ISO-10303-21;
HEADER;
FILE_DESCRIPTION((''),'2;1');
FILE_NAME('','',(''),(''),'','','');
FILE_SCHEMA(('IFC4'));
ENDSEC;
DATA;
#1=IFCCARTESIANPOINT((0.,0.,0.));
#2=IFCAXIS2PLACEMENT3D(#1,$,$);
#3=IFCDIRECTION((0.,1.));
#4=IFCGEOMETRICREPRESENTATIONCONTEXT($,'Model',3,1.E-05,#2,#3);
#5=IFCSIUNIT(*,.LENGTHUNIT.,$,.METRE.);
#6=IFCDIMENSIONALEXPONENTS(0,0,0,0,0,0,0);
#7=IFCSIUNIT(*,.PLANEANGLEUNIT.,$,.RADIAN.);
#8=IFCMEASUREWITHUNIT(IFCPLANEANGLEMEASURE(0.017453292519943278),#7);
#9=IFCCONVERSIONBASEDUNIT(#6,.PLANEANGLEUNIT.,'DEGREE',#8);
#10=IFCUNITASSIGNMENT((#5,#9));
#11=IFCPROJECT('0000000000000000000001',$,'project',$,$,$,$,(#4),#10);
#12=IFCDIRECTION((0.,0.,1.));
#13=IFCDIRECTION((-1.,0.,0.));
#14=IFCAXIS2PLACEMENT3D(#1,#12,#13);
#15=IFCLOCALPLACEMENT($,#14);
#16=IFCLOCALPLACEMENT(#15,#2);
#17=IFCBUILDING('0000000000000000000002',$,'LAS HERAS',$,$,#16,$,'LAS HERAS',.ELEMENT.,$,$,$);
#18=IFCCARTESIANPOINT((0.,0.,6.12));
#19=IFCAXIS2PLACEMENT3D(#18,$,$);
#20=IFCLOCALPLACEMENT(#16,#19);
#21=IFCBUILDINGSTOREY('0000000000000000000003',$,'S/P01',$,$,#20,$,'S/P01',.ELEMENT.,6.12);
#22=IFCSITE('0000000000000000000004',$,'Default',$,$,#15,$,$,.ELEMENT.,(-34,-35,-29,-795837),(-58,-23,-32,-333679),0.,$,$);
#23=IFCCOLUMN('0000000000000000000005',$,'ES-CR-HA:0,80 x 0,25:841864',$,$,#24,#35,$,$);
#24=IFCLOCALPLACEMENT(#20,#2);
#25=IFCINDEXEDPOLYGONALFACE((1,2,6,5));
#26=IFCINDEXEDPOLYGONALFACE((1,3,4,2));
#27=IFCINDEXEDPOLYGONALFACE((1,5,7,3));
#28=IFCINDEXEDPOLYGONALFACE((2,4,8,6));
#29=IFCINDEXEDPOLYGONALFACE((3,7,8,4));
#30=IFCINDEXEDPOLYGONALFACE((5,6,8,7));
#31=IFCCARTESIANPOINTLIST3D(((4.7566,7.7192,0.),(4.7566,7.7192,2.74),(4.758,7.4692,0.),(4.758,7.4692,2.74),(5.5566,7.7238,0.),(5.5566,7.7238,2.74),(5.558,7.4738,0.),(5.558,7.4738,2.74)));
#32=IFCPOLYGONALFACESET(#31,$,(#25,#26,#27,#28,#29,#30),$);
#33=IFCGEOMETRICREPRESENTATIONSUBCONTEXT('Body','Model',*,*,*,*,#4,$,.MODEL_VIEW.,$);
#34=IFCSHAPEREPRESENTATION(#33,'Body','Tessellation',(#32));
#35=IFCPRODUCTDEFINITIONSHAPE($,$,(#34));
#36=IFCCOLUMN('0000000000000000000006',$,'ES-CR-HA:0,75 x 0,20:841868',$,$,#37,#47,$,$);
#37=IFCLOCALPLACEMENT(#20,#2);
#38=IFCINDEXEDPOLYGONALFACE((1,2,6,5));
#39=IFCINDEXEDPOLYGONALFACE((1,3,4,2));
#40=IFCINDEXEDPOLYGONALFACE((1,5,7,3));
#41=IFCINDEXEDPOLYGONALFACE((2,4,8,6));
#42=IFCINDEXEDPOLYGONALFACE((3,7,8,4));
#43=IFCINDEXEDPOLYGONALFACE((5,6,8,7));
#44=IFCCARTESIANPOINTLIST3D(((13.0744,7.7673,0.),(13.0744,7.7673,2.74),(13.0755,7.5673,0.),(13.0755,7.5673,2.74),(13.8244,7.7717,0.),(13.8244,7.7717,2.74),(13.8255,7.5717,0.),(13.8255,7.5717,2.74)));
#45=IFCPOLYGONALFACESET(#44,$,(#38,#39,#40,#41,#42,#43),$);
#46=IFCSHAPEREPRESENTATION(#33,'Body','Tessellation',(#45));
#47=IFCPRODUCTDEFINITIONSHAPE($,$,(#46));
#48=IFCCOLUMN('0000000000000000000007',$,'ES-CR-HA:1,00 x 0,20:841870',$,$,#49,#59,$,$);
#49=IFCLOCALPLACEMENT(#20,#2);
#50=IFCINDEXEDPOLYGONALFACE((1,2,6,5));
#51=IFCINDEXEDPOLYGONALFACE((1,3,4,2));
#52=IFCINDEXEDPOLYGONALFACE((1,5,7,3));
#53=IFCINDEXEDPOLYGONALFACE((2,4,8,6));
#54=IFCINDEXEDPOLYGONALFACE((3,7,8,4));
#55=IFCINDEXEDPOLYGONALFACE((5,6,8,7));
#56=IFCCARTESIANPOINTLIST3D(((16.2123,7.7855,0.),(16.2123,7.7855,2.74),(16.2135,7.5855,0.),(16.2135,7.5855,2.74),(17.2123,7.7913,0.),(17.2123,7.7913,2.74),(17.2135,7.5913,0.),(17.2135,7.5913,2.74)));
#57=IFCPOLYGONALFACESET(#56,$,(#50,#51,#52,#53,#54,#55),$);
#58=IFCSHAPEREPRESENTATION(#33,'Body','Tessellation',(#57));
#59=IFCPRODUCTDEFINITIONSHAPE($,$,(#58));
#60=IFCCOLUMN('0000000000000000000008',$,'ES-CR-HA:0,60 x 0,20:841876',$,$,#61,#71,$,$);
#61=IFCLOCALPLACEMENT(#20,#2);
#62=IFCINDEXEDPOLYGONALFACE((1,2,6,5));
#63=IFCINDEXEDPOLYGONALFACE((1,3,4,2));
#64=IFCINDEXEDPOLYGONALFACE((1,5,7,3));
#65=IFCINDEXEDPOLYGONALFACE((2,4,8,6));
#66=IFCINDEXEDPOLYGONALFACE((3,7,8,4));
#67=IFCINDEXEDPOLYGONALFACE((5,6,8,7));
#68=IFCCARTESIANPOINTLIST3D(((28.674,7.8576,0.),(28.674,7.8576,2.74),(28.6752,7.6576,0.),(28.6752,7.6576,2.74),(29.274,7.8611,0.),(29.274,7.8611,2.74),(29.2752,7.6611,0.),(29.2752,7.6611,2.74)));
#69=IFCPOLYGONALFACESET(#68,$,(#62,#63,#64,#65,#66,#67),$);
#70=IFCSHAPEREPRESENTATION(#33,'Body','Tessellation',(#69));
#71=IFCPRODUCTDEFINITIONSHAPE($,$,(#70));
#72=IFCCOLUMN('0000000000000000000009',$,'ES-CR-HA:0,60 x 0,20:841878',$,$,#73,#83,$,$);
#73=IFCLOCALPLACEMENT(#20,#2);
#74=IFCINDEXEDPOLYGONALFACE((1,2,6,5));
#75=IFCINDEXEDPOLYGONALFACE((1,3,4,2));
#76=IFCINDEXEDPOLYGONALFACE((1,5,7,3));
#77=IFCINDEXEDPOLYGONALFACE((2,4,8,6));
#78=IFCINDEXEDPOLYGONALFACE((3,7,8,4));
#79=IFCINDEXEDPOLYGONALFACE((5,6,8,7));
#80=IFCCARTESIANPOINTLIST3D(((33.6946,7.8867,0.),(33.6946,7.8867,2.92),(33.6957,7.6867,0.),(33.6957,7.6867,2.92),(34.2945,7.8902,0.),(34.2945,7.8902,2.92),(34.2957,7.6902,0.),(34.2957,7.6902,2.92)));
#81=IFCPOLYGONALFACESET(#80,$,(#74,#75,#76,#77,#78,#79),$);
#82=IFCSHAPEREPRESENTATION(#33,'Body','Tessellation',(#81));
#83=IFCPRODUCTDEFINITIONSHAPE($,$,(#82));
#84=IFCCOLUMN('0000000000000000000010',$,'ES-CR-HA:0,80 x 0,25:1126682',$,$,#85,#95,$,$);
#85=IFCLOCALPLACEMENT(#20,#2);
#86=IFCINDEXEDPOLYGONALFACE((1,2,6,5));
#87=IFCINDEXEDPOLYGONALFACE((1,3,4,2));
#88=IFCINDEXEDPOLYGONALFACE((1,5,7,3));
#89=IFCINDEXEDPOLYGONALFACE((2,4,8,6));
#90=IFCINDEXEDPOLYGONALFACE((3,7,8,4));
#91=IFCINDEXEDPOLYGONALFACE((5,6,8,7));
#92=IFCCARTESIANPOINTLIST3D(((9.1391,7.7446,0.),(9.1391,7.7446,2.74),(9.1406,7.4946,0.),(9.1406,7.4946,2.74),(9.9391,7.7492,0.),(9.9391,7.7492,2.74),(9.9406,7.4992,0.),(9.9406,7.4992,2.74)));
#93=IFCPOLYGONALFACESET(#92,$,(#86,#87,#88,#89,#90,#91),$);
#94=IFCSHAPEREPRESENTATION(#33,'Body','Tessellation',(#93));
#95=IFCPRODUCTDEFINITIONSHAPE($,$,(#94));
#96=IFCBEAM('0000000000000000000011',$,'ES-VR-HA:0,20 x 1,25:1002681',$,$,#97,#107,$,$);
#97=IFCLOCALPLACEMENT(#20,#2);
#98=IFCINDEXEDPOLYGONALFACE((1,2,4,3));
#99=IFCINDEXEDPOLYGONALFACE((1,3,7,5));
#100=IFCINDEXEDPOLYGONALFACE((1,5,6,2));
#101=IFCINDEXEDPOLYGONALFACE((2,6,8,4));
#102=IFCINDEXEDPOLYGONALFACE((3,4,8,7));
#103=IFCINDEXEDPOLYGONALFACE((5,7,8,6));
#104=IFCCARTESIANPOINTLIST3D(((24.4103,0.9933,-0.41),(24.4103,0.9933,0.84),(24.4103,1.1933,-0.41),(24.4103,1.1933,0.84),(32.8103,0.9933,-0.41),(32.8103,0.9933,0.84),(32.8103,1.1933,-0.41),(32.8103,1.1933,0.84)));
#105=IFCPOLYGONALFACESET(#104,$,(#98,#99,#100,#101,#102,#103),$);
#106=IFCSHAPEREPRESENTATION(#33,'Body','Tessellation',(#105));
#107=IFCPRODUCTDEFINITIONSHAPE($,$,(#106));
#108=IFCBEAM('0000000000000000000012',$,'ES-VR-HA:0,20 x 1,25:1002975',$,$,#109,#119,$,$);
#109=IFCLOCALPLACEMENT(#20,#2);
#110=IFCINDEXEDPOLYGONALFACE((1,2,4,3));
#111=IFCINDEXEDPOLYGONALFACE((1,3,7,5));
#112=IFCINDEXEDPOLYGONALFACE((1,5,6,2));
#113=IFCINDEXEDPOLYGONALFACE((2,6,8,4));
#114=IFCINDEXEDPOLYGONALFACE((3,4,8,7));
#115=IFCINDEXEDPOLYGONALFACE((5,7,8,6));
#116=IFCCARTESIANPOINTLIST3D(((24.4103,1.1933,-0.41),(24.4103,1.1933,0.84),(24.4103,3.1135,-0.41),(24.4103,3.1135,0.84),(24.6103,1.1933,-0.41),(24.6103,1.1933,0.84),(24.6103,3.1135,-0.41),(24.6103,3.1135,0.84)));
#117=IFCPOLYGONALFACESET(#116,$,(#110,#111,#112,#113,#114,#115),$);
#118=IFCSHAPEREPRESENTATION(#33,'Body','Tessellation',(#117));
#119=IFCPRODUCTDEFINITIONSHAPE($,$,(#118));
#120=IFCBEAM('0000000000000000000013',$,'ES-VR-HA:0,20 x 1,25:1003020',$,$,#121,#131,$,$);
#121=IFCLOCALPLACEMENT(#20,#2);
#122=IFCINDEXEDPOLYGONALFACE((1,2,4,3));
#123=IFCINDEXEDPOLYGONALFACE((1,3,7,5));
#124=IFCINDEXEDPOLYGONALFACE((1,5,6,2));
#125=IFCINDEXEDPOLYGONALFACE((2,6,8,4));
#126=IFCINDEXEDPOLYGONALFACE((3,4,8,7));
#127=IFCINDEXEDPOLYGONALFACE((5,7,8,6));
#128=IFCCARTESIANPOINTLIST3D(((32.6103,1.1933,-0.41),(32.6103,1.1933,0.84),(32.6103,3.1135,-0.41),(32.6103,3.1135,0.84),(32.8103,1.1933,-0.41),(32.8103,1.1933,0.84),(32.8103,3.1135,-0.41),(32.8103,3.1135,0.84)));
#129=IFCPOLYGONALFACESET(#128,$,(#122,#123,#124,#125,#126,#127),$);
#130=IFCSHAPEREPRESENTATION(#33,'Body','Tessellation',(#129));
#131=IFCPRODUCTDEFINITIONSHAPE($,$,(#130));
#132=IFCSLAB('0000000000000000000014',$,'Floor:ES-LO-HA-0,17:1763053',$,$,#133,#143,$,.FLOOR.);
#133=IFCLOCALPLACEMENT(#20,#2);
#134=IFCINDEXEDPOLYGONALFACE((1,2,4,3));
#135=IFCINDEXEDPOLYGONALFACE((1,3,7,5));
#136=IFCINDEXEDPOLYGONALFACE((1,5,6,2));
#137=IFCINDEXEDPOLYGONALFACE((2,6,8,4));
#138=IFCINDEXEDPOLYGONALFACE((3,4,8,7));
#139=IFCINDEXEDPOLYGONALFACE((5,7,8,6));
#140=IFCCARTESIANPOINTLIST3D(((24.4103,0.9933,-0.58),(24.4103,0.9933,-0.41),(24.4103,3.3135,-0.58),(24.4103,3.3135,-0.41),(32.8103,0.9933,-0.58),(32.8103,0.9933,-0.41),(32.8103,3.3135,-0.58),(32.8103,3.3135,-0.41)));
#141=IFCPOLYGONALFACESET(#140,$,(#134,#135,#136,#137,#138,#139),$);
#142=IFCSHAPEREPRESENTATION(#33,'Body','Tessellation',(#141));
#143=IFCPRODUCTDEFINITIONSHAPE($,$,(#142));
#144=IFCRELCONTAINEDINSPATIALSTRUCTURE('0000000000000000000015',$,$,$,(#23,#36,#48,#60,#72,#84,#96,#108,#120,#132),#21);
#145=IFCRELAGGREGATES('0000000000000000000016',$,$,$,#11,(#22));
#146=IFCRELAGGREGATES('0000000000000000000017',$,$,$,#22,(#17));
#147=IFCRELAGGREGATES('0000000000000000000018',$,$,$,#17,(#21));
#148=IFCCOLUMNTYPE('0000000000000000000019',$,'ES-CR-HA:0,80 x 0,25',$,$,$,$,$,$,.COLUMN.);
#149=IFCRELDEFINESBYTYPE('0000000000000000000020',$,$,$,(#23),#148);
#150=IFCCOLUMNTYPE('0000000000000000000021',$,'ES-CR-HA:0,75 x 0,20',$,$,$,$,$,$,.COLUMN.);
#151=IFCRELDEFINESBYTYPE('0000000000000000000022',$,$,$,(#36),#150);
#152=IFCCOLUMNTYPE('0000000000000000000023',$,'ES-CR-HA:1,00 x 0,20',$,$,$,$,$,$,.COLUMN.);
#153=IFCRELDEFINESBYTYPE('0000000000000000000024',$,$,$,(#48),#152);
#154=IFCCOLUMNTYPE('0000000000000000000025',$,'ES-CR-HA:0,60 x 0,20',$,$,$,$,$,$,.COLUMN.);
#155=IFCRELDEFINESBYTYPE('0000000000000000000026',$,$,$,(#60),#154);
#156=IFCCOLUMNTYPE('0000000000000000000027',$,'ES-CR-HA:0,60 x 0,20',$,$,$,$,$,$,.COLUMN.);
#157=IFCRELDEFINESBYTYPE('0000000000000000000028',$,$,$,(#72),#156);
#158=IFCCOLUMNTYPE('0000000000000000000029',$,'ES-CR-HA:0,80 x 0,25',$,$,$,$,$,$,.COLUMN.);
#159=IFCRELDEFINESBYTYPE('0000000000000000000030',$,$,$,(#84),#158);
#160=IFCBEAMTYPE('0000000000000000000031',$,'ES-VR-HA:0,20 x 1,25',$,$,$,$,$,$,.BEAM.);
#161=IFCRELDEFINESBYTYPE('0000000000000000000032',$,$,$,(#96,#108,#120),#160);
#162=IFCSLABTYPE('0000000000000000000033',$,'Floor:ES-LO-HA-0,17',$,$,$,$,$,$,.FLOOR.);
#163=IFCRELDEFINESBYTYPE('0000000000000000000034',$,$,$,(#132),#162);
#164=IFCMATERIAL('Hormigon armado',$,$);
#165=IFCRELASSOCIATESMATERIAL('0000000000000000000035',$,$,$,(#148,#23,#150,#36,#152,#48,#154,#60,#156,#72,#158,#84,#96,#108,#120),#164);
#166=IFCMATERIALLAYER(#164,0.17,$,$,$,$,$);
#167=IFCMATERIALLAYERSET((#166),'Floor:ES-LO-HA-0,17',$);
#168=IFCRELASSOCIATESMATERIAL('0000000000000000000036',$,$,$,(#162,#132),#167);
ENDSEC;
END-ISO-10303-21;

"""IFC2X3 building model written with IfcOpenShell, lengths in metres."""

from ifc_helpers import new_model, entity, si_unit, converted_unit, direction, frame, frame_2d, origin, origin_2d_with_axis, place, context, subcontext, project, spatial, rectangle, extrude, source, transform, mapped, material, layer, layer_set, layer_usage, type_object, type_shapes, element, save


model = new_model("IFC2X3")

# Units and contexts
model_context = context("Model", 3, precision=1e-05, world=origin(), true_north=direction((0.0, 1.0)))
body_context = subcontext(model_context, "Body", "Model", "MODEL_VIEW")
ifc_project = project(units=[si_unit("LENGTHUNIT", "METRE"), converted_unit("PLANEANGLEUNIT", "DEGREE", entity("IfcPlaneAngleMeasure", 0.017453292519943278), si_unit("PLANEANGLEUNIT", "RADIAN"), dimensions=[0, 0, 0, 0, 0, 0, 0])], contexts=[model_context])

# Site, building, storey
site_placement = place(None, frame((0.0, 0.0, 0.0), z_axis=(0.0, 0.0, 1.0), x_axis=(-1.0, 0.0, 0.0)))
site = spatial("IfcSite", under=ifc_project, at=site_placement, Name="Default", CompositionType="ELEMENT", RefLatitude=(-34, -35, -29, -795837), RefLongitude=(-58, -23, -32, -333679), RefElevation=0.0)
building_placement = place(site_placement, origin())
building = spatial("IfcBuilding", under=site, at=building_placement, Name="LAS HERAS", LongName="LAS HERAS", CompositionType="ELEMENT")
storey_placement = place(building_placement, frame((0.0, 0.0, 6.12)))
storey = spatial("IfcBuildingStorey", under=building, at=storey_placement, Name="S/P01", LongName="S/P01", CompositionType="ELEMENT", Elevation=6.12)

# Columns
ifc_material_1 = material(Name="Hormigon armado")
column_type_1 = type_object("IfcColumnType", Name="ES-CR-HA:0,80 x 0,25", PredefinedType="COLUMN", material=ifc_material_1)
shared_shape_1 = source(origin(), body_context, "Body", "SweptSolid", [
    extrude(rectangle(XDim=0.8, YDim=0.25, at=frame_2d((0.0, 0.0), x_axis=(1.0, 0.0))), frame((5.1573, 7.5965, 6.12), z_axis=(0.0, 0.0, 1.0), x_axis=(-0.999983, -0.005788, 0.0)), (0.0, 0.0, 1.0), 2.74),
])
type_shapes(column_type_1, [shared_shape_1])
column_1_placement = place(storey_placement, frame((0.0, 0.0, -6.12)))
element("IfcColumn", 1, at=column_1_placement, inside=storey, type_object=column_type_1, material=ifc_material_1, Name="ES-CR-HA:0,80 x 0,25:841864", context=body_context, shape_type="MappedRepresentation", body=[
    mapped(shared_shape_1, transform((0.0, 0.0, 0.0), scale=1.0)),
])
column_type_2 = type_object("IfcColumnType", Name="ES-CR-HA:0,75 x 0,20", PredefinedType="COLUMN", material=ifc_material_1)
shared_shape_2 = source(origin(), body_context, "Body", "SweptSolid", [
    extrude(rectangle(XDim=0.75, YDim=0.2, at=origin_2d_with_axis()), frame((13.4499, 7.6695, 6.12), z_axis=(0.0, 0.0, 1.0), x_axis=(-0.999983, -0.005788, 0.0)), (0.0, 0.0, 1.0), 2.74),
])
type_shapes(column_type_2, [shared_shape_2])
column_2_placement = place(storey_placement, frame((0.0, 0.0, -6.12)))
element("IfcColumn", 2, at=column_2_placement, inside=storey, type_object=column_type_2, material=ifc_material_1, Name="ES-CR-HA:0,75 x 0,20:841868", context=body_context, shape_type="MappedRepresentation", body=[
    mapped(shared_shape_2, transform((0.0, 0.0, 0.0), scale=1.0)),
])
column_type_3 = type_object("IfcColumnType", Name="ES-CR-HA:1,00 x 0,20", PredefinedType="COLUMN", material=ifc_material_1)
shared_shape_3 = source(origin(), body_context, "Body", "SweptSolid", [
    extrude(rectangle(XDim=1.0, YDim=0.2, at=frame_2d((0.0, 0.0), x_axis=(1.0, 0.0))), frame((16.7129, 7.6884, 6.12), z_axis=(0.0, 0.0, 1.0), x_axis=(-0.999983, -0.005788, 0.0)), (0.0, 0.0, 1.0), 2.74),
])
type_shapes(column_type_3, [shared_shape_3])
column_3_placement = place(storey_placement, frame((0.0, 0.0, -6.12)))
element("IfcColumn", 3, at=column_3_placement, inside=storey, type_object=column_type_3, material=ifc_material_1, Name="ES-CR-HA:1,00 x 0,20:841870", context=body_context, shape_type="MappedRepresentation", body=[
    mapped(shared_shape_3, transform((0.0, 0.0, 0.0), scale=1.0)),
])
column_type_4 = type_object("IfcColumnType", Name="ES-CR-HA:0,60 x 0,20", PredefinedType="COLUMN", material=ifc_material_1)
shared_shape_4 = source(origin(), body_context, "Body", "SweptSolid", [
    extrude(rectangle(XDim=2.74, YDim=0.2, at=frame_2d((0.0, 0.0), x_axis=(1.0, 0.0))), frame((28.6746, 7.7576, 7.49), z_axis=(0.999983, 0.00576, 0.0), x_axis=(0.0, 0.0, 1.0)), (0.0, 0.0, 1.0), 0.6),
])
type_shapes(column_type_4, [shared_shape_4])
column_4_placement = place(storey_placement, frame((0.0, 0.0, -6.12)))
element("IfcColumn", 4, at=column_4_placement, inside=storey, type_object=column_type_4, material=ifc_material_1, Name="ES-CR-HA:0,60 x 0,20:841876", context=body_context, shape_type="MappedRepresentation", body=[
    mapped(shared_shape_4, transform((0.0, 0.0, 0.0), scale=1.0)),
])
column_type_5 = type_object("IfcColumnType", Name="ES-CR-HA:0,60 x 0,20", PredefinedType="COLUMN", material=ifc_material_1)
shared_shape_5 = source(origin(), body_context, "Body", "SweptSolid", [
    extrude(rectangle(XDim=0.6, YDim=0.2, at=frame_2d((0.0, 0.0), x_axis=(1.0, 0.0))), frame((33.9951, 7.7884, 6.12), z_axis=(0.0, 0.0, 1.0), x_axis=(-0.999983, -0.005788, 0.0)), (0.0, 0.0, 1.0), 2.92),
])
type_shapes(column_type_5, [shared_shape_5])
column_5_placement = place(storey_placement, frame((0.0, 0.0, -6.12)))
element("IfcColumn", 5, at=column_5_placement, inside=storey, type_object=column_type_5, material=ifc_material_1, Name="ES-CR-HA:0,60 x 0,20:841878", context=body_context, shape_type="MappedRepresentation", body=[
    mapped(shared_shape_5, transform((0.0, 0.0, 0.0), scale=1.0)),
])
column_type_6 = type_object("IfcColumnType", Name="ES-CR-HA:0,80 x 0,25", PredefinedType="COLUMN", material=ifc_material_1)
shared_shape_6 = source(origin(), body_context, "Body", "SweptSolid", [
    extrude(rectangle(XDim=0.8, YDim=0.25, at=frame_2d((0.0, 0.0), x_axis=(1.0, 0.0))), frame((9.5399, 7.6219, 6.12), z_axis=(0.0, 0.0, 1.0), x_axis=(-0.999983, -0.005788, 0.0)), (0.0, 0.0, 1.0), 2.74),
])
type_shapes(column_type_6, [shared_shape_6])
column_6_placement = place(storey_placement, frame((0.0, 0.0, -6.12)))
element("IfcColumn", 6, at=column_6_placement, inside=storey, type_object=column_type_6, material=ifc_material_1, Name="ES-CR-HA:0,80 x 0,25:1126682", context=body_context, shape_type="MappedRepresentation", body=[
    mapped(shared_shape_6, transform((0.0, 0.0, 0.0), scale=1.0)),
])

# Beams
beam_type = type_object("IfcBeamType", Name="ES-VR-HA:0,20 x 1,25", PredefinedType="BEAM")
beam_1_placement = place(storey_placement, frame((24.5103, 1.0933, 0.84)))
element("IfcBeam", 7, at=beam_1_placement, inside=storey, type_object=beam_type, material=ifc_material_1, Name="ES-VR-HA:0,20 x 1,25:1002681", context=body_context, shape_type="SweptSolid", body=[
    extrude(rectangle(XDim=1.25, YDim=0.2, at=origin_2d_with_axis()), frame((-0.1, 0.0, -0.625), z_axis=(1.0, 0.0, 0.0), x_axis=(0.0, 0.0, -1.0)), (0.0, 0.0, 1.0), 8.4),
])
beam_2_placement = place(storey_placement, frame((24.5103, 1.0933, 0.84), z_axis=(0.0, 0.0, 1.0), x_axis=(0.0, 1.0, 0.0)))
element("IfcBeam", 8, at=beam_2_placement, inside=storey, type_object=beam_type, material=ifc_material_1, Name="ES-VR-HA:0,20 x 1,25:1002975", context=body_context, shape_type="SweptSolid", body=[
    extrude(rectangle(XDim=1.25, YDim=0.2, at=frame_2d((0.0, 0.0), x_axis=(1.0, 0.0))), frame((0.1, 0.0, -0.625), z_axis=(1.0, 0.0, 0.0), x_axis=(0.0, 0.0, -1.0)), (0.0, 0.0, 1.0), 1.9202),
])
beam_3_placement = place(storey_placement, frame((32.7103, 1.0933, 0.84), z_axis=(0.0, 0.0, 1.0), x_axis=(0.0, 1.0, 0.0)))
element("IfcBeam", 9, at=beam_3_placement, inside=storey, type_object=beam_type, material=ifc_material_1, Name="ES-VR-HA:0,20 x 1,25:1003020", context=body_context, shape_type="SweptSolid", body=[
    extrude(rectangle(XDim=1.25, YDim=0.2, at=frame_2d((0.0, 0.0), x_axis=(1.0, 0.0))), frame((0.1, 0.0, -0.625), z_axis=(1.0, 0.0, 0.0), x_axis=(0.0, 0.0, -1.0)), (0.0, 0.0, 1.0), 1.9202),
])

# Slab
ifc_layer_1 = layer(ifc_material_1, 0.17)
ifc_layer_set_1 = layer_set([ifc_layer_1], Name="Floor:ES-LO-HA-0,17")
ifc_layer_usage_1 = layer_usage(ifc_layer_set_1, "AXIS3", "POSITIVE", 0.0)
slab_type_1 = type_object("IfcSlabType", Name="Floor:ES-LO-HA-0,17", PredefinedType="FLOOR", material=ifc_layer_set_1)
slab_1_placement = place(storey_placement, origin())
element("IfcSlab", 10, at=slab_1_placement, inside=storey, type_object=slab_type_1, material=ifc_layer_usage_1, Name="Floor:ES-LO-HA-0,17:1763053", PredefinedType="FLOOR", context=body_context, shape_type="SweptSolid", body=[
    extrude(rectangle(XDim=2.3202, YDim=8.4, at=frame_2d((0.0, 0.0), x_axis=(1.0, 0.0))), frame((28.6103, 2.1534, -0.41), z_axis=(0.0, 0.0, -1.0), x_axis=(0.0, 1.0, 0.0)), (0.0, 0.0, 1.0), 0.17),
])

save(model, "model.ifc")
